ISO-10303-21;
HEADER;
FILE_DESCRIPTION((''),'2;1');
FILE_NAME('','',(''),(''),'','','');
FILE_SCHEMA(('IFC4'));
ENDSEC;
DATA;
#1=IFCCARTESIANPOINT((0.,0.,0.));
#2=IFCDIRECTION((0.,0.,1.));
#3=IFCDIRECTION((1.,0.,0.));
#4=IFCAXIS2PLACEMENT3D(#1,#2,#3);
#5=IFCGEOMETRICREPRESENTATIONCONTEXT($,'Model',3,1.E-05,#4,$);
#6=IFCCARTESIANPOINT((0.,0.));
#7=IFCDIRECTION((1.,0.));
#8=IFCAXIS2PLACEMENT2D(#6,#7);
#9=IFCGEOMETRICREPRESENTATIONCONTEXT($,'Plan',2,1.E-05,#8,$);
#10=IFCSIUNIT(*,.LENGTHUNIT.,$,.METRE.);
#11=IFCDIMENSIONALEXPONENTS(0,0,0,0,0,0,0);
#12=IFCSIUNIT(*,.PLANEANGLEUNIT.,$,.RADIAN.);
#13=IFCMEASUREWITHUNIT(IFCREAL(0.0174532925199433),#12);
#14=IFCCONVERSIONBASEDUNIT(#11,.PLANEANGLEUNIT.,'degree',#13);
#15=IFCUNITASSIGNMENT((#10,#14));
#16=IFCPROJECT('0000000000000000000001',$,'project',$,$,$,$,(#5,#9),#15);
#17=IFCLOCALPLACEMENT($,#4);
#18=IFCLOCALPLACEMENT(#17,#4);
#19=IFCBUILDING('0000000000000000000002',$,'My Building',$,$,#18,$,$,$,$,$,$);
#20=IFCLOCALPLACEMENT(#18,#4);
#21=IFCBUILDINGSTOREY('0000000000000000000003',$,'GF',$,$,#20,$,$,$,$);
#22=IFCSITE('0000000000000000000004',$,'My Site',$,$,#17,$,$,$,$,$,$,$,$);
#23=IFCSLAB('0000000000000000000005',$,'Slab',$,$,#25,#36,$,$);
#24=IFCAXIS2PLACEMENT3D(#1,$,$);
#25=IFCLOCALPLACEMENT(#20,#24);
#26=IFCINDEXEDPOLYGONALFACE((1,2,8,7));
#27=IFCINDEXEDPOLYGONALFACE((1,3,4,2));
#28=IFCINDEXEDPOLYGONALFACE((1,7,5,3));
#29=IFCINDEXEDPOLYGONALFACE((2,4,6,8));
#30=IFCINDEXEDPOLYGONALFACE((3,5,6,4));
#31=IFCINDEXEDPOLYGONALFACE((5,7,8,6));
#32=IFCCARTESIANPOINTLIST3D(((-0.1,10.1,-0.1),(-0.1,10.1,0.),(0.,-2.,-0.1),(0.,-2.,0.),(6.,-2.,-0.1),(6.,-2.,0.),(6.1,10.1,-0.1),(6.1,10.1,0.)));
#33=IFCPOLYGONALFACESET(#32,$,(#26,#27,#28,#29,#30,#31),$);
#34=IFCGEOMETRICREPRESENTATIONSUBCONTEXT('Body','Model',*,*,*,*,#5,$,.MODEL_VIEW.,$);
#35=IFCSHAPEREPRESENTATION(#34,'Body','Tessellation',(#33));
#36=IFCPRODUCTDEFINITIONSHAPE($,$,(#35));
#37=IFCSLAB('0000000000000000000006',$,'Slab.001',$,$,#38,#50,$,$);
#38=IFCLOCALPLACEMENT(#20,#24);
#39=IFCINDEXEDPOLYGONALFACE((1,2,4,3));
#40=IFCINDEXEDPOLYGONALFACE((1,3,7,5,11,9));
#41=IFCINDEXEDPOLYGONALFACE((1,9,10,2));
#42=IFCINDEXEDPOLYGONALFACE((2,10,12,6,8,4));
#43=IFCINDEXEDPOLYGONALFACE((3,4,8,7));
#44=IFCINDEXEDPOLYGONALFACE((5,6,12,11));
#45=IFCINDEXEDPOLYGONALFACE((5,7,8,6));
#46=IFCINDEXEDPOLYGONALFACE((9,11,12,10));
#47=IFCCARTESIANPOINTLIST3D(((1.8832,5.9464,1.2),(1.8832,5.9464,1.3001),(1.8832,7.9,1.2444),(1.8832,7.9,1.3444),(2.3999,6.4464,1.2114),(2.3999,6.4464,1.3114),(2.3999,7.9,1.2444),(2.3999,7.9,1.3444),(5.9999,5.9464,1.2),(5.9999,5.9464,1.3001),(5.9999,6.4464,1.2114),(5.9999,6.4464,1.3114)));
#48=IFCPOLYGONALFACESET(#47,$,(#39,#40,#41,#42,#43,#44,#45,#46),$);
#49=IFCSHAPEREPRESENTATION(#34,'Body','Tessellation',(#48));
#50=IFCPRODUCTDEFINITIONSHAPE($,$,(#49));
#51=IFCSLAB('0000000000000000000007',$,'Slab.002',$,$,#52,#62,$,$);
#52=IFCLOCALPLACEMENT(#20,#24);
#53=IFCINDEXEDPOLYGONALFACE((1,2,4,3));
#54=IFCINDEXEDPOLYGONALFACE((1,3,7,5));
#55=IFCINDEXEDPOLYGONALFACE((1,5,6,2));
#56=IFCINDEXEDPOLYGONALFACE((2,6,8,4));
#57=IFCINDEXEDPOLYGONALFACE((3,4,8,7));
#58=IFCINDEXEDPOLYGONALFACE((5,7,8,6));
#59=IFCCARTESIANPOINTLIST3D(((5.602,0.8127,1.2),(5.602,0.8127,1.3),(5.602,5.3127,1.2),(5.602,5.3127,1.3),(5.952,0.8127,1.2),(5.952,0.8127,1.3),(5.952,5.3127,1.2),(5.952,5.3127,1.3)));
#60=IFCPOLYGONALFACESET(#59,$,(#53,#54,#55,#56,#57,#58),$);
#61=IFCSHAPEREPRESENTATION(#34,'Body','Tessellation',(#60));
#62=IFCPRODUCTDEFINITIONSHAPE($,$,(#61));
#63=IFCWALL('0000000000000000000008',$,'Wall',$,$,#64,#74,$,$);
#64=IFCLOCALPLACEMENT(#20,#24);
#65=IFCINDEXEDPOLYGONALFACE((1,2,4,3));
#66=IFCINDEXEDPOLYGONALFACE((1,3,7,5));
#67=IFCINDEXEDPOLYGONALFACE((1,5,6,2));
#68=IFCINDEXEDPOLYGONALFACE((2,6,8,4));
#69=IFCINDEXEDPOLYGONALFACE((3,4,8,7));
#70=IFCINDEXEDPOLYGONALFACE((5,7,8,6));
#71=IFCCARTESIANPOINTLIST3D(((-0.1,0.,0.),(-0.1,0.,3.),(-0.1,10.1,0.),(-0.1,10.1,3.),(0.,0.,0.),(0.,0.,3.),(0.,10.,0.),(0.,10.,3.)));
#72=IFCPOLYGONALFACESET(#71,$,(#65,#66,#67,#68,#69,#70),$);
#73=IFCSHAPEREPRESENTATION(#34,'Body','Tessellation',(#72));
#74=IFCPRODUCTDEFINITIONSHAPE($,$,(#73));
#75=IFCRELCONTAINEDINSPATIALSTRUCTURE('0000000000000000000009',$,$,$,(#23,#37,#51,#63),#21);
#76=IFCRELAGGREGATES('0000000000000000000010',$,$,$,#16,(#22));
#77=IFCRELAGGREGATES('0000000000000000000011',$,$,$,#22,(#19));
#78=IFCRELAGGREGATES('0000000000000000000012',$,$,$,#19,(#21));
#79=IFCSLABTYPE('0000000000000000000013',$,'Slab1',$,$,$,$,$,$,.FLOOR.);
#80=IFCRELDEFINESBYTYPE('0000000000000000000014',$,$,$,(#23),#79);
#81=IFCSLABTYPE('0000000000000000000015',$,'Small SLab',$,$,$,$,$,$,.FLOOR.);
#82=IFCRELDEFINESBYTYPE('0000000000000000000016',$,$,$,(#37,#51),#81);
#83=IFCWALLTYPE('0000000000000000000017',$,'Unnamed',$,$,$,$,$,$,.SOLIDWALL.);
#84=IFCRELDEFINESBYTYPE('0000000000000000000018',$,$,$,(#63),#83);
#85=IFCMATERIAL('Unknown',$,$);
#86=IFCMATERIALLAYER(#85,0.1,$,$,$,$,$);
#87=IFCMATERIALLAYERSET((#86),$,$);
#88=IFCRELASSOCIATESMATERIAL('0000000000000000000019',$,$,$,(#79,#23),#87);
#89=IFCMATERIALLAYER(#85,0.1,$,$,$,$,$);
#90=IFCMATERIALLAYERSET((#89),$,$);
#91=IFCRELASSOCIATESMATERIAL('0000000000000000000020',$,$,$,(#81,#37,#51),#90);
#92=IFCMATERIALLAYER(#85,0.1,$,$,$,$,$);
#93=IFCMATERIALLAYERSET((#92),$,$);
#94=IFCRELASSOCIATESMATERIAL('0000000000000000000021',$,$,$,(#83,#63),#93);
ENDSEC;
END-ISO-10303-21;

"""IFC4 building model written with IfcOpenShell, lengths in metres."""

from ifc_helpers import new_model, entity, si_unit, converted_unit, frame, origin_with_axes, origin_2d_with_axis, place, context, subcontext, project, spatial, line, indexed_curve, outline, extrude, material, layer, layer_set, layer_usage, type_object, element, save


model = new_model("IFC4")

# Units and contexts
model_context = context("Model", 3, precision=1e-05, world=origin_with_axes())
plan_context = context("Plan", 2, precision=1e-05, world=origin_2d_with_axis())
body_context_1 = subcontext(model_context, "Body", "Model", "MODEL_VIEW")
ifc_project = project(units=[si_unit("LENGTHUNIT", "METRE"), converted_unit("PLANEANGLEUNIT", "degree", entity("IfcReal", 0.0174532925199433), si_unit("PLANEANGLEUNIT", "RADIAN"), dimensions=[0, 0, 0, 0, 0, 0, 0])], contexts=[model_context, plan_context])

# Site, building, storey
site_placement = place(None, origin_with_axes())
site = spatial("IfcSite", under=ifc_project, at=site_placement, Name="My Site")
building_placement = place(site_placement, origin_with_axes())
building = spatial("IfcBuilding", under=site, at=building_placement, Name="My Building")
storey_placement = place(building_placement, origin_with_axes())
storey = spatial("IfcBuildingStorey", under=building, at=storey_placement, Name="GF")

# Slabs
ifc_material = material(Name="Unknown")
ifc_layer_1 = layer(ifc_material, 0.1)
ifc_layer_set_1 = layer_set([ifc_layer_1])
ifc_layer_usage_1 = layer_usage(ifc_layer_set_1, "AXIS3", "POSITIVE", -0.1)
slab_type_1 = type_object("IfcSlabType", Name="Slab1", PredefinedType="FLOOR", material=ifc_layer_set_1)
slab_1_placement = place(storey_placement, frame((-0.1, 10.1, 0.0), z_axis=(0.0, 0.0, 1.0), x_axis=(1.0, 0.0, 0.0)))
element("IfcSlab", 1, at=slab_1_placement, inside=storey, type_object=slab_type_1, material=ifc_layer_usage_1, Name="Slab", context=body_context_1, shape_type="SweptSolid", body=[
    extrude(outline(indexed_curve([(0.0, 0.0), (6.2, 0.0), (6.1, -12.1), (0.1, -12.1), (0.0, 0.0)])), frame((0.0, 0.0, -0.1), z_axis=(0.0, 0.0, 1.0), x_axis=(1.0, 0.0, 0.0)), (0.0, 0.0, 1.0), 0.1),
])
ifc_layer_2 = layer(ifc_material, 0.1)
ifc_layer_set_2 = layer_set([ifc_layer_2])
ifc_layer_usage_2 = layer_usage(ifc_layer_set_2, "AXIS3", "POSITIVE", -0.1)
slab_type_2 = type_object("IfcSlabType", Name="Small SLab", PredefinedType="FLOOR", material=ifc_layer_set_2)
slab_2_placement = place(storey_placement, frame((1.8832, 5.9464, 1.3001), z_axis=(0.0, -0.022687, 0.999743), x_axis=(1.0, 0.0, 0.0)))
element("IfcSlab", 2, at=slab_2_placement, inside=storey, type_object=slab_type_2, material=ifc_layer_usage_2, Name="Slab.001", context=body_context_1, shape_type="SweptSolid", body=[
    extrude(outline(indexed_curve([(0.0, 0.0), (4.1168, 0.0), (4.1168, 0.5001), (0.5168, 0.5001), (0.5168, 1.9541), (0.0, 1.9541), (0.0, 0.0)])), frame((0.0, -0.0023, -0.1), z_axis=(0.0, 0.0, 1.0), x_axis=(1.0, 0.0, 0.0)), (0.0, 0.022687, 0.999743), 0.1),
])
ifc_layer_usage_3 = layer_usage(ifc_layer_set_2, "AXIS3", "POSITIVE", -0.1)
slab_3_placement = place(storey_placement, frame((5.952, 5.3127, 1.3), z_axis=(0.0, 0.0, 1.0), x_axis=(1.0, 0.0, 0.0)))
element("IfcSlab", 3, at=slab_3_placement, inside=storey, type_object=slab_type_2, material=ifc_layer_usage_3, Name="Slab.002", context=body_context_1, shape_type="SweptSolid", body=[
    extrude(outline(indexed_curve([(0.0, 0.0), (-0.35, 0.0), (-0.35, -4.5), (0.0, -4.5), (0.0, 0.0)])), frame((0.0, 0.0, -0.1), z_axis=(0.0, 0.0, 1.0), x_axis=(1.0, 0.0, 0.0)), (0.0, 0.0, 1.0), 0.1),
])

# Wall
ifc_layer_3 = layer(ifc_material, 0.1)
ifc_layer_set_3 = layer_set([ifc_layer_3])
ifc_layer_usage_4 = layer_usage(ifc_layer_set_3, "AXIS2", "POSITIVE", 0.0)
wall_type_1 = type_object("IfcWallType", Name="Unnamed", PredefinedType="SOLIDWALL", material=ifc_layer_set_3)
wall_1_placement = place(storey_placement, frame((0.0, 0.0, 0.0), z_axis=(0.0, 0.0, 1.0), x_axis=(0.0, 1.0, 0.0)))
element("IfcWall", 4, at=wall_1_placement, inside=storey, type_object=wall_type_1, material=ifc_layer_usage_4, Name="Wall", context=body_context_1, shape_type="SweptSolid", body=[
    extrude(outline(indexed_curve([(0.0, 0.0), (0.0, 0.1), (10.1, 0.1), (10.0, 0.0)], segments=[line(1, 2, 3, 4, 1)])), origin_with_axes(), (0.0, 0.0, 1.0), 3.0),
])

save(model, "model.ifc")
